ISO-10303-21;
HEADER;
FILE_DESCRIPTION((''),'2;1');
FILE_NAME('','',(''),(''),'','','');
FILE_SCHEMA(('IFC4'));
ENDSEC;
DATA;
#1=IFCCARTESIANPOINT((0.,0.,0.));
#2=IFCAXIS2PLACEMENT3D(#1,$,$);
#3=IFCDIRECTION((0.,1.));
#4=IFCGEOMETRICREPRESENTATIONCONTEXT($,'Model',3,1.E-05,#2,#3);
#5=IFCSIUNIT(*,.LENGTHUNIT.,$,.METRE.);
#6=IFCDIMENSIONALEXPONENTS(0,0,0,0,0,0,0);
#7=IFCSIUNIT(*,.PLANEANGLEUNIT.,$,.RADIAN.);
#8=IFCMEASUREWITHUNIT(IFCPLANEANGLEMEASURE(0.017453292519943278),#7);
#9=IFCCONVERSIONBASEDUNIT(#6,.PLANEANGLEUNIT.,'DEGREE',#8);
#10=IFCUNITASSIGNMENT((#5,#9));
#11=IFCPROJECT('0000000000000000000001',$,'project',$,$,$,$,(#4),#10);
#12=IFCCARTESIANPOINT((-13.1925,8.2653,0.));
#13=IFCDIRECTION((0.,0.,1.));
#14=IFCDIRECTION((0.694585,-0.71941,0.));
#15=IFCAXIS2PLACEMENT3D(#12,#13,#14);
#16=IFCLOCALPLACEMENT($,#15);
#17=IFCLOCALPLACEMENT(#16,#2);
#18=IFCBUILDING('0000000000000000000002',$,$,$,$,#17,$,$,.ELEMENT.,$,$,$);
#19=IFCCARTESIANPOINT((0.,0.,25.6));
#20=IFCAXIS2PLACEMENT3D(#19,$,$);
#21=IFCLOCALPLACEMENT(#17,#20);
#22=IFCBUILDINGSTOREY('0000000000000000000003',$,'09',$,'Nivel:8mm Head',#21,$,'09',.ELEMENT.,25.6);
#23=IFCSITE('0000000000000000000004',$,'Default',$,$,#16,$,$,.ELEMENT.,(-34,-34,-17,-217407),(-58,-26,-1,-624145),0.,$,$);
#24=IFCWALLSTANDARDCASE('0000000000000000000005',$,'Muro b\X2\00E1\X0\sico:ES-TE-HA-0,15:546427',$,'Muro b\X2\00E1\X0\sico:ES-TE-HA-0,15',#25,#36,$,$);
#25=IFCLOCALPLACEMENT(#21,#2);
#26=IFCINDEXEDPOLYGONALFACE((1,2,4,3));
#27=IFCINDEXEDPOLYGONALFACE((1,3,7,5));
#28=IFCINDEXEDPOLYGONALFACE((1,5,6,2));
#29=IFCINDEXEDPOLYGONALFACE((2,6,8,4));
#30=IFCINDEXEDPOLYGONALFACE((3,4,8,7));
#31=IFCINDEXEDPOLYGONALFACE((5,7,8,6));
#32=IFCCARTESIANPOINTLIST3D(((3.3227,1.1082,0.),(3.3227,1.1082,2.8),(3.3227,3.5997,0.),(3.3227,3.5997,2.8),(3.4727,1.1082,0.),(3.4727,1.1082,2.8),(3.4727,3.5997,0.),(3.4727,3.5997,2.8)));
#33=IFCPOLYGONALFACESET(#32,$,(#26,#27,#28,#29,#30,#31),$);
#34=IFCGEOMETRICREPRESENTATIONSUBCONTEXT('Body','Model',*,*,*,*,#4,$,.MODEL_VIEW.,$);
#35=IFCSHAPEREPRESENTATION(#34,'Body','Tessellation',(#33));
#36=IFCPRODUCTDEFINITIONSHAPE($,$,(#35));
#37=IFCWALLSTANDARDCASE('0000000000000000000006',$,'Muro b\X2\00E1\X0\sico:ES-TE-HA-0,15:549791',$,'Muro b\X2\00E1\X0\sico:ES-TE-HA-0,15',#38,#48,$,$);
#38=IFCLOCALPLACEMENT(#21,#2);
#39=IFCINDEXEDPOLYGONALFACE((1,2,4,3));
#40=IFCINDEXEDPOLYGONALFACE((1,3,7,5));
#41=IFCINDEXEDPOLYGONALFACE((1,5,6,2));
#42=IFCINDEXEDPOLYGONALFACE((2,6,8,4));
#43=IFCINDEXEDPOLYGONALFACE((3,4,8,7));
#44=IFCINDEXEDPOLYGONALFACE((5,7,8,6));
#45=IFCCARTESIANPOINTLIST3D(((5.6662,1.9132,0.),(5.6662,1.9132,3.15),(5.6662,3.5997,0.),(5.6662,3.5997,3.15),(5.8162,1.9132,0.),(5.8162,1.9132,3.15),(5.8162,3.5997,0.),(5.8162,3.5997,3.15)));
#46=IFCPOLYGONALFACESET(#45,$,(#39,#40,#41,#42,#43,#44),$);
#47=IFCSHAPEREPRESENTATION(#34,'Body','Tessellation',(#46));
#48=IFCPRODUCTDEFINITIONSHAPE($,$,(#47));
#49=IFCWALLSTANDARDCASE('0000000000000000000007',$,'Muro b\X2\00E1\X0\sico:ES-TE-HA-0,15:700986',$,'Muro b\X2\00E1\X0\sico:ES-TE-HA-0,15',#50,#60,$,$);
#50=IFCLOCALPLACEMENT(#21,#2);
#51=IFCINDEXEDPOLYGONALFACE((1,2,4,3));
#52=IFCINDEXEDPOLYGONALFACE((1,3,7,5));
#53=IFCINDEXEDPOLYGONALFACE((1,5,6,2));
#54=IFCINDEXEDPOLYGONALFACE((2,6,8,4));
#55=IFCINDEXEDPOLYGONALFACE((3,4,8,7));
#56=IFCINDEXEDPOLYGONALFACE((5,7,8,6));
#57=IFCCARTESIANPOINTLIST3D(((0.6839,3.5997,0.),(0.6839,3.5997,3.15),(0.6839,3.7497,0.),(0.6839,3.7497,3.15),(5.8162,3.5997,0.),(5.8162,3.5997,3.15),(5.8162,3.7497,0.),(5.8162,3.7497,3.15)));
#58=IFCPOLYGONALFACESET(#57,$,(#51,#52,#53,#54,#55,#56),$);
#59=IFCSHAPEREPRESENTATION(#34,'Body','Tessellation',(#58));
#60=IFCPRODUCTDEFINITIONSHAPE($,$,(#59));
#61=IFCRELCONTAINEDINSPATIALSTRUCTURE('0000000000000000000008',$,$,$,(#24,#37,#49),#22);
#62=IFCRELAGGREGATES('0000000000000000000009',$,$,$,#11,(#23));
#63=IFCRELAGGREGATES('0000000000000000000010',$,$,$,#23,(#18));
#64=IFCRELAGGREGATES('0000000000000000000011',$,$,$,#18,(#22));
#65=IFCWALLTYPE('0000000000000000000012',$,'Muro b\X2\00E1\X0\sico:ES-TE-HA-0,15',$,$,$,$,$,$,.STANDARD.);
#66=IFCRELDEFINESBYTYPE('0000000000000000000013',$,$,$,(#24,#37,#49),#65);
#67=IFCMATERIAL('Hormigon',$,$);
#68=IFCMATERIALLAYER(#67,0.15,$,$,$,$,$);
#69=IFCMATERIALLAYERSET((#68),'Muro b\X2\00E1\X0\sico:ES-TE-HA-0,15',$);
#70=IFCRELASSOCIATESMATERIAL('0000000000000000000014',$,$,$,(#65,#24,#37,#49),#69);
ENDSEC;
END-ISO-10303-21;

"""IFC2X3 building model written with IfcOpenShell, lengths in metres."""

from ifc_helpers import new_model, entity, si_unit, converted_unit, direction, frame, frame_2d, origin, place, context, subcontext, project, spatial, rectangle, extrude, material, layer, layer_set, layer_usage, type_object, element, save


model = new_model("IFC2X3")

# Units and contexts
model_context = context("Model", 3, precision=1e-05, world=origin(), true_north=direction((0.0, 1.0)))
body_context = subcontext(model_context, "Body", "Model", "MODEL_VIEW")
ifc_project = project(units=[si_unit("LENGTHUNIT", "METRE"), converted_unit("PLANEANGLEUNIT", "DEGREE", entity("IfcPlaneAngleMeasure", 0.017453292519943278), si_unit("PLANEANGLEUNIT", "RADIAN"), dimensions=[0, 0, 0, 0, 0, 0, 0])], contexts=[model_context])

# Site, building, storey
site_placement = place(None, frame((-13.1925, 8.2653, 0.0), z_axis=(0.0, 0.0, 1.0), x_axis=(0.694585, -0.71941, 0.0)))
site = spatial("IfcSite", under=ifc_project, at=site_placement, Name="Default", CompositionType="ELEMENT", RefLatitude=(-34, -34, -17, -217407), RefLongitude=(-58, -26, -1, -624145), RefElevation=0.0)
building_placement = place(site_placement, origin())
building = spatial("IfcBuilding", under=site, at=building_placement, CompositionType="ELEMENT")
storey_placement = place(building_placement, frame((0.0, 0.0, 25.6)))
storey = spatial("IfcBuildingStorey", under=building, at=storey_placement, Name="09", ObjectType="Nivel:8mm Head", LongName="09", CompositionType="ELEMENT", Elevation=25.6)

# Shared definitions
ifc_material_1 = material(Name="Hormigon")

# Walls
ifc_layer_1 = layer(ifc_material_1, 0.15)
ifc_layer_set_1 = layer_set([ifc_layer_1], Name="Muro básico:ES-TE-HA-0,15")
wall_type = type_object("IfcWallType", Name="Muro básico:ES-TE-HA-0,15", PredefinedType="STANDARD", material=ifc_layer_set_1)
ifc_layer_usage_1 = layer_usage(ifc_layer_set_1, "AXIS2", "NEGATIVE", 0.075)
wall_1_placement = place(storey_placement, frame((3.3977, 3.5997, 0.0), z_axis=(0.0, 0.0, 1.0), x_axis=(0.0, -1.0, 0.0)))
element("IfcWallStandardCase", 1, at=wall_1_placement, inside=storey, type_object=wall_type, material=ifc_layer_usage_1, Name="Muro básico:ES-TE-HA-0,15:546427", ObjectType="Muro básico:ES-TE-HA-0,15", context=body_context, shape_type="SweptSolid", body=[
    extrude(rectangle(XDim=2.4914, YDim=0.15, at=frame_2d((1.2457, 0.0), x_axis=(-1.0, 0.0))), origin(), (0.0, 0.0, 1.0), 2.8),
])
ifc_layer_usage_2 = layer_usage(ifc_layer_set_1, "AXIS2", "POSITIVE", -0.075)
wall_2_placement = place(storey_placement, frame((5.7412, 3.5997, 0.0), z_axis=(0.0, 0.0, 1.0), x_axis=(0.0, -1.0, 0.0)))
element("IfcWallStandardCase", 2, at=wall_2_placement, inside=storey, type_object=wall_type, material=ifc_layer_usage_2, Name="Muro básico:ES-TE-HA-0,15:549791", ObjectType="Muro básico:ES-TE-HA-0,15", context=body_context, shape_type="SweptSolid", body=[
    extrude(rectangle(XDim=1.6864, YDim=0.15, at=frame_2d((0.8432, 0.0), x_axis=(-1.0, 0.0))), origin(), (0.0, 0.0, 1.0), 3.15),
])
ifc_layer_usage_3 = layer_usage(ifc_layer_set_1, "AXIS2", "NEGATIVE", 0.075)
wall_3_placement = place(storey_placement, frame((0.6839, 3.6747, 0.0)))
element("IfcWallStandardCase", 3, at=wall_3_placement, inside=storey, type_object=wall_type, material=ifc_layer_usage_3, Name="Muro básico:ES-TE-HA-0,15:700986", ObjectType="Muro básico:ES-TE-HA-0,15", context=body_context, shape_type="SweptSolid", body=[
    extrude(rectangle(XDim=5.1323, YDim=0.15, at=frame_2d((2.5661, 0.0), x_axis=(-1.0, 0.0))), origin(), (0.0, 0.0, 1.0), 3.15),
])

save(model, "model.ifc")
